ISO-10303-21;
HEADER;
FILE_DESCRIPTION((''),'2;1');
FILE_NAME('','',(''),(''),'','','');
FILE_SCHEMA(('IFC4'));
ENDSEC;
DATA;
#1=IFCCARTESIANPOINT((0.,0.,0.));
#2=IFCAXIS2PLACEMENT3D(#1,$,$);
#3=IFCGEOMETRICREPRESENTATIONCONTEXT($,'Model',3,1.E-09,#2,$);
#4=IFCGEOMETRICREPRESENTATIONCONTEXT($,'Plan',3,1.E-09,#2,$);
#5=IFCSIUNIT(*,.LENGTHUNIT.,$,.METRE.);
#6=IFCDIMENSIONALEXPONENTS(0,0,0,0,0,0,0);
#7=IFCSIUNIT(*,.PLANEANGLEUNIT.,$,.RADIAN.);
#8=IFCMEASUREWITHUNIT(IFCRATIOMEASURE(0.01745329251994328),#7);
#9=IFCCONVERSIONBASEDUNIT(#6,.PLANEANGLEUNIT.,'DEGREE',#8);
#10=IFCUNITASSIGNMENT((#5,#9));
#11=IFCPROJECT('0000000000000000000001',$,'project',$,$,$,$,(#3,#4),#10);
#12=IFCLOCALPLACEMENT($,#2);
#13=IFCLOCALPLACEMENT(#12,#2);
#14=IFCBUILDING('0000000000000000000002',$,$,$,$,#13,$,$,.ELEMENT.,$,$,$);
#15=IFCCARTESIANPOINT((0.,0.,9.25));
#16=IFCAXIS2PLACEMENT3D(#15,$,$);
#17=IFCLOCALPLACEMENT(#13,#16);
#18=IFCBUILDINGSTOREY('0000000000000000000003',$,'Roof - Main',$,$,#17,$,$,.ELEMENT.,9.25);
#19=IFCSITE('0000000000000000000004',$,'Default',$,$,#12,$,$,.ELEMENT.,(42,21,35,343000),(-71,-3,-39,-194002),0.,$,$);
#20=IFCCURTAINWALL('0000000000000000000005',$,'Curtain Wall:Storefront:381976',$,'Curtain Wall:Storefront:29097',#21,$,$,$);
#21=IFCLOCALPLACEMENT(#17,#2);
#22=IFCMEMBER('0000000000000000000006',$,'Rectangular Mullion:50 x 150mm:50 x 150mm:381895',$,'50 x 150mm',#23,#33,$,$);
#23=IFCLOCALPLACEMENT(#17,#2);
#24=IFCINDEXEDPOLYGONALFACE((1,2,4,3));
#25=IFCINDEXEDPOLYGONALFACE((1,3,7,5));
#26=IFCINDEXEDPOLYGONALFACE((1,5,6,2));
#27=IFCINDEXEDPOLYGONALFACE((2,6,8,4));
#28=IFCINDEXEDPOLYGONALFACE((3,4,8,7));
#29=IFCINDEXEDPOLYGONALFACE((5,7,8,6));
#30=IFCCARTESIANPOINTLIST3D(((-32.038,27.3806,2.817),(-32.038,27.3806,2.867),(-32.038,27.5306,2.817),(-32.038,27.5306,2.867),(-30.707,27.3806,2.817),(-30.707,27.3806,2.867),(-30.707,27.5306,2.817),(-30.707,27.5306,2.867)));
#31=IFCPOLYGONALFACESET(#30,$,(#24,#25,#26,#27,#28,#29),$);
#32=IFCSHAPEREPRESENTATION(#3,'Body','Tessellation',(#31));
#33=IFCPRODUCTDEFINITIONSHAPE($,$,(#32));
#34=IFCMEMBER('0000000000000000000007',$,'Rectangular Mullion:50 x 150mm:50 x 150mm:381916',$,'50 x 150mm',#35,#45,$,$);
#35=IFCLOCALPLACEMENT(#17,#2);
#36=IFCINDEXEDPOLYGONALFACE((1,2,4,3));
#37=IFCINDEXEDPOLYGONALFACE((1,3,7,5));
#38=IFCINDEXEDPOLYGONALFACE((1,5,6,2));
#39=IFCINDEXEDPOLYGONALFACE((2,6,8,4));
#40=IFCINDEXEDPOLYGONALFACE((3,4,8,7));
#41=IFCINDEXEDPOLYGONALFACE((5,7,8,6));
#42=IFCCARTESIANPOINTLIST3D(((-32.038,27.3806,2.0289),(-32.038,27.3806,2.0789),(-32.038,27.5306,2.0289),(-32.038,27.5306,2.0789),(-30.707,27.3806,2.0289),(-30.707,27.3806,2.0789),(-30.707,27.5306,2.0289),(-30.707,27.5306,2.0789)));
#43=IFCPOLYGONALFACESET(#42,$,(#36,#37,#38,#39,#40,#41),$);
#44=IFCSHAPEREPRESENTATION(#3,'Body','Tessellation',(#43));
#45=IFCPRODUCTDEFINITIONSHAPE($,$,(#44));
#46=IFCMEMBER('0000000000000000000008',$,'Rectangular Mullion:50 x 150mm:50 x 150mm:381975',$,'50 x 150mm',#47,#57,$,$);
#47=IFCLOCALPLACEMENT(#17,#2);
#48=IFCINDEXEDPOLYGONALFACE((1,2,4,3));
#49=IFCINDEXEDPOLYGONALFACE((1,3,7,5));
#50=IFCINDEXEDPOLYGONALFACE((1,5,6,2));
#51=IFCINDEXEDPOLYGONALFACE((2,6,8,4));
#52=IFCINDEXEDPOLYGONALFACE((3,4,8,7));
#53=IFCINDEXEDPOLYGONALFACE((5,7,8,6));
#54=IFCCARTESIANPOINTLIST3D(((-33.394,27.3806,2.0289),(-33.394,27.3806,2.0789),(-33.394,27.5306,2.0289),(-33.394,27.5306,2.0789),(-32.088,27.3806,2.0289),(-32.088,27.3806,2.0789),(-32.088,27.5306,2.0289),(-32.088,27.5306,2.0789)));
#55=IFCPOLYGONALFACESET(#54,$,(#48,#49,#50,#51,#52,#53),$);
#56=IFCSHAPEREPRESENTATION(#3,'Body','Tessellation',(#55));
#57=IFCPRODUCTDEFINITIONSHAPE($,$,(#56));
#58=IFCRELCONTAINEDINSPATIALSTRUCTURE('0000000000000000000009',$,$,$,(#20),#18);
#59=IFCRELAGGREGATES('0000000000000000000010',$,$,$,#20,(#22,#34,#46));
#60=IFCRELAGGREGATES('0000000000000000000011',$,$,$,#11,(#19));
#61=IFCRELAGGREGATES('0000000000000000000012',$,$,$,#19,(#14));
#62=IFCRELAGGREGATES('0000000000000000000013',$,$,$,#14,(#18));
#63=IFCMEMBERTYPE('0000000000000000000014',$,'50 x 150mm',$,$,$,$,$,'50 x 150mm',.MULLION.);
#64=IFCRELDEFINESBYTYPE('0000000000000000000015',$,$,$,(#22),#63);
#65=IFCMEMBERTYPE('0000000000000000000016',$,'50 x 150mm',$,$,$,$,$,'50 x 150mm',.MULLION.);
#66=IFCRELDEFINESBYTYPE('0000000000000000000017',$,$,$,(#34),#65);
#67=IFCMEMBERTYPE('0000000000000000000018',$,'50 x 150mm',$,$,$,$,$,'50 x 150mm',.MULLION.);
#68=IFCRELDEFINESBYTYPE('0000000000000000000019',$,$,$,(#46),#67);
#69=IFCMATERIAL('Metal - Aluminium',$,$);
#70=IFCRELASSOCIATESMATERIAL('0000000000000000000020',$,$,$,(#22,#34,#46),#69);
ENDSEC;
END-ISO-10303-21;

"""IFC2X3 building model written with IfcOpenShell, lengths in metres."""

from ifc_helpers import new_model, entity, si_unit, converted_unit, frame, origin, origin_2d_with_axis, place, context, project, spatial, rectangle, extrude, source, transform, mapped, material, type_object, type_shapes, element, aggregate, save


model = new_model("IFC2X3")

# Units and contexts
model_context = context("Model", 3, precision=1e-09, world=origin())
plan_context = context("Plan", 3, precision=1e-09, world=origin())
ifc_project = project(units=[si_unit("LENGTHUNIT", "METRE"), converted_unit("PLANEANGLEUNIT", "DEGREE", entity("IfcRatioMeasure", 0.01745329251994328), si_unit("PLANEANGLEUNIT", "RADIAN"), dimensions=[0, 0, 0, 0, 0, 0, 0])], contexts=[model_context, plan_context])

# Site, building, storey
site_placement = place(None, origin())
site = spatial("IfcSite", under=ifc_project, at=site_placement, Name="Default", CompositionType="ELEMENT", RefLatitude=(42, 21, 35, 343000), RefLongitude=(-71, -3, -39, -194002), RefElevation=0.0)
building_placement = place(site_placement, origin())
building = spatial("IfcBuilding", under=site, at=building_placement, CompositionType="ELEMENT")
storey_placement = place(building_placement, frame((0.0, 0.0, 9.25)))
storey = spatial("IfcBuildingStorey", under=building, at=storey_placement, Name="Roof - Main", CompositionType="ELEMENT", Elevation=9.25)

# Curtain wall
curtain_wall_1_placement = place(storey_placement, origin())
curtain_wall_1 = element("IfcCurtainWall", 1, at=curtain_wall_1_placement, inside=storey, Name="Curtain Wall:Storefront:381976", ObjectType="Curtain Wall:Storefront:29097")
ifc_material_1 = material(Name="Metal - Aluminium")

# Members
member_type_1 = type_object("IfcMemberType", Name="50 x 150mm", ElementType="50 x 150mm", PredefinedType="MULLION")
shared_shape_1 = source(origin(), model_context, "Body", "SweptSolid", [
    extrude(rectangle(XDim=0.05, YDim=0.15, at=origin_2d_with_axis()), frame((-0.025, 0.0, -1.331), z_axis=(0.0, 0.0, 1.0), x_axis=(-1.0, 0.0, 0.0)), (0.0, 0.0, 1.0), 1.331),
])
type_shapes(member_type_1, [shared_shape_1])
member_1_placement = place(storey_placement, frame((-30.707, 27.4556, 2.867), z_axis=(1.0, 0.0, 0.0), x_axis=(0.0, 0.0, 1.0)))
member_1 = element("IfcMember", 2, at=member_1_placement, type_object=member_type_1, material=ifc_material_1, Name="Rectangular Mullion:50 x 150mm:50 x 150mm:381895", ObjectType="50 x 150mm", context=model_context, shape_type="MappedRepresentation", body=[
    mapped(shared_shape_1, transform((0.0, 0.0, 0.0), scale=1.0)),
])
member_type_2 = type_object("IfcMemberType", Name="50 x 150mm", ElementType="50 x 150mm", PredefinedType="MULLION")
shared_shape_2 = source(origin(), model_context, "Body", "SweptSolid", [
    extrude(rectangle(XDim=0.05, YDim=0.15, at=origin_2d_with_axis()), frame((0.0, 0.0, -1.331), z_axis=(0.0, 0.0, 1.0), x_axis=(-1.0, 0.0, 0.0)), (0.0, 0.0, 1.0), 1.331),
])
type_shapes(member_type_2, [shared_shape_2])
member_2_placement = place(storey_placement, frame((-30.707, 27.4556, 2.0539), z_axis=(1.0, 0.0, 0.0), x_axis=(0.0, 0.0, 1.0)))
member_2 = element("IfcMember", 3, at=member_2_placement, type_object=member_type_2, material=ifc_material_1, Name="Rectangular Mullion:50 x 150mm:50 x 150mm:381916", ObjectType="50 x 150mm", context=model_context, shape_type="MappedRepresentation", body=[
    mapped(shared_shape_2, transform((0.0, 0.0, 0.0), scale=1.0)),
])
member_type_3 = type_object("IfcMemberType", Name="50 x 150mm", ElementType="50 x 150mm", PredefinedType="MULLION")
shared_shape_3 = source(origin(), model_context, "Body", "SweptSolid", [
    extrude(rectangle(XDim=0.05, YDim=0.15, at=origin_2d_with_axis()), frame((0.0, 0.0, -1.306), z_axis=(0.0, 0.0, 1.0), x_axis=(-1.0, 0.0, 0.0)), (0.0, 0.0, 1.0), 1.306),
])
type_shapes(member_type_3, [shared_shape_3])
member_3_placement = place(storey_placement, frame((-32.088, 27.4556, 2.0539), z_axis=(1.0, 0.0, 0.0), x_axis=(0.0, 0.0, 1.0)))
member_3 = element("IfcMember", 4, at=member_3_placement, type_object=member_type_3, material=ifc_material_1, Name="Rectangular Mullion:50 x 150mm:50 x 150mm:381975", ObjectType="50 x 150mm", context=model_context, shape_type="MappedRepresentation", body=[
    mapped(shared_shape_3, transform((0.0, 0.0, 0.0), scale=1.0)),
])

aggregate(curtain_wall_1, [member_1, member_2, member_3])

save(model, "model.ifc")
